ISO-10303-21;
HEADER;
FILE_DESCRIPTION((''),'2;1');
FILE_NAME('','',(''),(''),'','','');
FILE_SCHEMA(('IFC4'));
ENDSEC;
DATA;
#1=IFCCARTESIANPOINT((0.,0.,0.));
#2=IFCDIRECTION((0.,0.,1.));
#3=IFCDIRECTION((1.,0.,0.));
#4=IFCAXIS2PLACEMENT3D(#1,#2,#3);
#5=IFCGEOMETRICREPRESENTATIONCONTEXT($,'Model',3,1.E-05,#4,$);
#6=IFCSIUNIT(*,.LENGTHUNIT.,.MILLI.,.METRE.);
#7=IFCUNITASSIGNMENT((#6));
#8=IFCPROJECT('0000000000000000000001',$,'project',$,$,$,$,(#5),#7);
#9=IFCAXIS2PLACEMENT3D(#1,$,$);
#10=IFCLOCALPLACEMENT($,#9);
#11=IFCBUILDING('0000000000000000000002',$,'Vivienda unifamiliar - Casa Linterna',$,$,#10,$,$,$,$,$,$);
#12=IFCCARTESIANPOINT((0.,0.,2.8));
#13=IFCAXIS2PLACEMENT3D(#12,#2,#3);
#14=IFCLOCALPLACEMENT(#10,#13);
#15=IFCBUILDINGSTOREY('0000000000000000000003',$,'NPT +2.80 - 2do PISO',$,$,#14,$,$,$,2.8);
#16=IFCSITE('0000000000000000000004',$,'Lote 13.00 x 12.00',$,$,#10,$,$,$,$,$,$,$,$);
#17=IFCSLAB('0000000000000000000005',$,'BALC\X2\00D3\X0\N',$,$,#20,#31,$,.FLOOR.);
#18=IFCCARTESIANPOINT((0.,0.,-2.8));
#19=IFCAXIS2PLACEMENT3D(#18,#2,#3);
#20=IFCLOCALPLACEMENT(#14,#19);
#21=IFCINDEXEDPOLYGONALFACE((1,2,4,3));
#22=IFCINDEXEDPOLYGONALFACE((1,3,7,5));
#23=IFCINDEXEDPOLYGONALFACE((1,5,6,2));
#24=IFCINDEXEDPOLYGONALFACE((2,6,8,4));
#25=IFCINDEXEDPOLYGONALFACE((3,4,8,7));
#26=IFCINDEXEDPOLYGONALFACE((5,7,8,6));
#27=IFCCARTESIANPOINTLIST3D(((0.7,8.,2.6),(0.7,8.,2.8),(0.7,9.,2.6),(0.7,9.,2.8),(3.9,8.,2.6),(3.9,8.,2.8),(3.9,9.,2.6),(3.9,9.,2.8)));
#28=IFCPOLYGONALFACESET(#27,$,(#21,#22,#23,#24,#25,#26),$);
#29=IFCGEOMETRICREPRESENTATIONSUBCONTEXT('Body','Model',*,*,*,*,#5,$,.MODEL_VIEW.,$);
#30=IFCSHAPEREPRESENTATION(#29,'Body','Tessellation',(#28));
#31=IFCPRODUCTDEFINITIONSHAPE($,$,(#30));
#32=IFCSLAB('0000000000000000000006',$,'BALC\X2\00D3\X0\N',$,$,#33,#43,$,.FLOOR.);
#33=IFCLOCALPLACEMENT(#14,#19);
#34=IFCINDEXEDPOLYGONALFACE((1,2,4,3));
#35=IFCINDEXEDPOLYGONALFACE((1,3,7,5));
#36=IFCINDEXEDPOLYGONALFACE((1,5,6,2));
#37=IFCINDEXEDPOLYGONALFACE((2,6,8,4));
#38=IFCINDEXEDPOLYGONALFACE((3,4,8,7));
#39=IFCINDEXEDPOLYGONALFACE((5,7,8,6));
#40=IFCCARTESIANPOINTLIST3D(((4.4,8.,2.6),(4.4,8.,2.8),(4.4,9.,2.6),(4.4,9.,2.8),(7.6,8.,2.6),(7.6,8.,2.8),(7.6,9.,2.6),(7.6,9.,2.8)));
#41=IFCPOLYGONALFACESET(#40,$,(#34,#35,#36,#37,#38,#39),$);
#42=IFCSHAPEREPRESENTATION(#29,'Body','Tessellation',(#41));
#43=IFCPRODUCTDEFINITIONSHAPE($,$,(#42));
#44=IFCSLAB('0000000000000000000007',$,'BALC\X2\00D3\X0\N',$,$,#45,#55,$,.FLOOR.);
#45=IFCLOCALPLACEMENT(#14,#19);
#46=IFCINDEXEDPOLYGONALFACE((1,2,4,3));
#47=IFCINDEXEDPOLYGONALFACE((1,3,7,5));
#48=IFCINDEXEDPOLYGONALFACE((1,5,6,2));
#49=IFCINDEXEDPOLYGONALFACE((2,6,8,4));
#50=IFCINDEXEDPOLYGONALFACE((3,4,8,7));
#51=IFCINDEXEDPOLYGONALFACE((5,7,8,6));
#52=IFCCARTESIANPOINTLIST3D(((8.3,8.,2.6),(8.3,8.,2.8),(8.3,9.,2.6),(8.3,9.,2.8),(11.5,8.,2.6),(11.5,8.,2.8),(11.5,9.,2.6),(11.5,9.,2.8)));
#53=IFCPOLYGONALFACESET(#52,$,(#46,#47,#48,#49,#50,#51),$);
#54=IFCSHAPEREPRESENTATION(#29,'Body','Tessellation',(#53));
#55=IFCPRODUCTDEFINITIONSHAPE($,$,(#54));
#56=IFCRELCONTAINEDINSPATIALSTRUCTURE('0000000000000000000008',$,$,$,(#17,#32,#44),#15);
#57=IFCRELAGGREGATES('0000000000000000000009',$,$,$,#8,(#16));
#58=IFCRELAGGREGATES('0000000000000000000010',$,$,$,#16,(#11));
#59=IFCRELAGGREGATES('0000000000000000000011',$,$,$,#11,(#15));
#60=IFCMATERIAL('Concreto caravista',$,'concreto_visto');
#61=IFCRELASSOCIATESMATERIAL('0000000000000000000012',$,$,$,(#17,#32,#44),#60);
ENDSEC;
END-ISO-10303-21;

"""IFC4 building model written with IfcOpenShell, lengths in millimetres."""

from ifc_helpers import new_model, si_unit, frame, origin, origin_with_axes, place, context, subcontext, project, spatial, polyline, outline, extrude, material, element, save


model = new_model("IFC4")

# Units and contexts
model_context = context("Model", 3, precision=1e-05, world=origin_with_axes())
body_context = subcontext(model_context, "Body", "Model", "MODEL_VIEW")
ifc_project = project(units=[si_unit("LENGTHUNIT", "METRE", prefix="MILLI")], contexts=[model_context])

# Site, building, storey
placement = place(None, origin())
site = spatial("IfcSite", under=ifc_project, at=placement, Name="Lote 13.00 x 12.00")
building = spatial("IfcBuilding", under=site, at=placement, Name="Vivienda unifamiliar - Casa Linterna")
storey_placement = place(placement, frame((0.0, 0.0, 2.8), z_axis=(0.0, 0.0, 1.0), x_axis=(1.0, 0.0, 0.0)))
storey = spatial("IfcBuildingStorey", under=building, at=storey_placement, Name="NPT +2.80 - 2do PISO", Elevation=2.8)

# Slabs
ifc_material_1 = material(Name="Concreto caravista", Category="concreto_visto")
slab_1_placement = place(storey_placement, frame((0.0, 0.0, -2.8), z_axis=(0.0, 0.0, 1.0), x_axis=(1.0, 0.0, 0.0)))
element("IfcSlab", 1, at=slab_1_placement, inside=storey, material=ifc_material_1, Name="BALCÓN", PredefinedType="FLOOR", context=body_context, shape_type="SweptSolid", body=[
    extrude(outline(polyline([(8.0, 2.6), (9.0, 2.6), (9.0, 2.8), (8.0, 2.8), (8.0, 2.6)])), frame((0.7, 0.0, 0.0), z_axis=(1.0, 0.0, 0.0), x_axis=(0.0, 1.0, 0.0)), (0.0, 0.0, 1.0), 3.2),
])
slab_2_placement = place(storey_placement, frame((0.0, 0.0, -2.8), z_axis=(0.0, 0.0, 1.0), x_axis=(1.0, 0.0, 0.0)))
element("IfcSlab", 2, at=slab_2_placement, inside=storey, material=ifc_material_1, Name="BALCÓN", PredefinedType="FLOOR", context=body_context, shape_type="SweptSolid", body=[
    extrude(outline(polyline([(8.0, 2.6), (9.0, 2.6), (9.0, 2.8), (8.0, 2.8), (8.0, 2.6)])), frame((4.4, 0.0, 0.0), z_axis=(1.0, 0.0, 0.0), x_axis=(0.0, 1.0, 0.0)), (0.0, 0.0, 1.0), 3.2),
])
slab_3_placement = place(storey_placement, frame((0.0, 0.0, -2.8), z_axis=(0.0, 0.0, 1.0), x_axis=(1.0, 0.0, 0.0)))
element("IfcSlab", 3, at=slab_3_placement, inside=storey, material=ifc_material_1, Name="BALCÓN", PredefinedType="FLOOR", context=body_context, shape_type="SweptSolid", body=[
    extrude(outline(polyline([(8.0, 2.6), (9.0, 2.6), (9.0, 2.8), (8.0, 2.8), (8.0, 2.6)])), frame((8.3, 0.0, 0.0), z_axis=(1.0, 0.0, 0.0), x_axis=(0.0, 1.0, 0.0)), (0.0, 0.0, 1.0), 3.2),
])

save(model, "model.ifc")
